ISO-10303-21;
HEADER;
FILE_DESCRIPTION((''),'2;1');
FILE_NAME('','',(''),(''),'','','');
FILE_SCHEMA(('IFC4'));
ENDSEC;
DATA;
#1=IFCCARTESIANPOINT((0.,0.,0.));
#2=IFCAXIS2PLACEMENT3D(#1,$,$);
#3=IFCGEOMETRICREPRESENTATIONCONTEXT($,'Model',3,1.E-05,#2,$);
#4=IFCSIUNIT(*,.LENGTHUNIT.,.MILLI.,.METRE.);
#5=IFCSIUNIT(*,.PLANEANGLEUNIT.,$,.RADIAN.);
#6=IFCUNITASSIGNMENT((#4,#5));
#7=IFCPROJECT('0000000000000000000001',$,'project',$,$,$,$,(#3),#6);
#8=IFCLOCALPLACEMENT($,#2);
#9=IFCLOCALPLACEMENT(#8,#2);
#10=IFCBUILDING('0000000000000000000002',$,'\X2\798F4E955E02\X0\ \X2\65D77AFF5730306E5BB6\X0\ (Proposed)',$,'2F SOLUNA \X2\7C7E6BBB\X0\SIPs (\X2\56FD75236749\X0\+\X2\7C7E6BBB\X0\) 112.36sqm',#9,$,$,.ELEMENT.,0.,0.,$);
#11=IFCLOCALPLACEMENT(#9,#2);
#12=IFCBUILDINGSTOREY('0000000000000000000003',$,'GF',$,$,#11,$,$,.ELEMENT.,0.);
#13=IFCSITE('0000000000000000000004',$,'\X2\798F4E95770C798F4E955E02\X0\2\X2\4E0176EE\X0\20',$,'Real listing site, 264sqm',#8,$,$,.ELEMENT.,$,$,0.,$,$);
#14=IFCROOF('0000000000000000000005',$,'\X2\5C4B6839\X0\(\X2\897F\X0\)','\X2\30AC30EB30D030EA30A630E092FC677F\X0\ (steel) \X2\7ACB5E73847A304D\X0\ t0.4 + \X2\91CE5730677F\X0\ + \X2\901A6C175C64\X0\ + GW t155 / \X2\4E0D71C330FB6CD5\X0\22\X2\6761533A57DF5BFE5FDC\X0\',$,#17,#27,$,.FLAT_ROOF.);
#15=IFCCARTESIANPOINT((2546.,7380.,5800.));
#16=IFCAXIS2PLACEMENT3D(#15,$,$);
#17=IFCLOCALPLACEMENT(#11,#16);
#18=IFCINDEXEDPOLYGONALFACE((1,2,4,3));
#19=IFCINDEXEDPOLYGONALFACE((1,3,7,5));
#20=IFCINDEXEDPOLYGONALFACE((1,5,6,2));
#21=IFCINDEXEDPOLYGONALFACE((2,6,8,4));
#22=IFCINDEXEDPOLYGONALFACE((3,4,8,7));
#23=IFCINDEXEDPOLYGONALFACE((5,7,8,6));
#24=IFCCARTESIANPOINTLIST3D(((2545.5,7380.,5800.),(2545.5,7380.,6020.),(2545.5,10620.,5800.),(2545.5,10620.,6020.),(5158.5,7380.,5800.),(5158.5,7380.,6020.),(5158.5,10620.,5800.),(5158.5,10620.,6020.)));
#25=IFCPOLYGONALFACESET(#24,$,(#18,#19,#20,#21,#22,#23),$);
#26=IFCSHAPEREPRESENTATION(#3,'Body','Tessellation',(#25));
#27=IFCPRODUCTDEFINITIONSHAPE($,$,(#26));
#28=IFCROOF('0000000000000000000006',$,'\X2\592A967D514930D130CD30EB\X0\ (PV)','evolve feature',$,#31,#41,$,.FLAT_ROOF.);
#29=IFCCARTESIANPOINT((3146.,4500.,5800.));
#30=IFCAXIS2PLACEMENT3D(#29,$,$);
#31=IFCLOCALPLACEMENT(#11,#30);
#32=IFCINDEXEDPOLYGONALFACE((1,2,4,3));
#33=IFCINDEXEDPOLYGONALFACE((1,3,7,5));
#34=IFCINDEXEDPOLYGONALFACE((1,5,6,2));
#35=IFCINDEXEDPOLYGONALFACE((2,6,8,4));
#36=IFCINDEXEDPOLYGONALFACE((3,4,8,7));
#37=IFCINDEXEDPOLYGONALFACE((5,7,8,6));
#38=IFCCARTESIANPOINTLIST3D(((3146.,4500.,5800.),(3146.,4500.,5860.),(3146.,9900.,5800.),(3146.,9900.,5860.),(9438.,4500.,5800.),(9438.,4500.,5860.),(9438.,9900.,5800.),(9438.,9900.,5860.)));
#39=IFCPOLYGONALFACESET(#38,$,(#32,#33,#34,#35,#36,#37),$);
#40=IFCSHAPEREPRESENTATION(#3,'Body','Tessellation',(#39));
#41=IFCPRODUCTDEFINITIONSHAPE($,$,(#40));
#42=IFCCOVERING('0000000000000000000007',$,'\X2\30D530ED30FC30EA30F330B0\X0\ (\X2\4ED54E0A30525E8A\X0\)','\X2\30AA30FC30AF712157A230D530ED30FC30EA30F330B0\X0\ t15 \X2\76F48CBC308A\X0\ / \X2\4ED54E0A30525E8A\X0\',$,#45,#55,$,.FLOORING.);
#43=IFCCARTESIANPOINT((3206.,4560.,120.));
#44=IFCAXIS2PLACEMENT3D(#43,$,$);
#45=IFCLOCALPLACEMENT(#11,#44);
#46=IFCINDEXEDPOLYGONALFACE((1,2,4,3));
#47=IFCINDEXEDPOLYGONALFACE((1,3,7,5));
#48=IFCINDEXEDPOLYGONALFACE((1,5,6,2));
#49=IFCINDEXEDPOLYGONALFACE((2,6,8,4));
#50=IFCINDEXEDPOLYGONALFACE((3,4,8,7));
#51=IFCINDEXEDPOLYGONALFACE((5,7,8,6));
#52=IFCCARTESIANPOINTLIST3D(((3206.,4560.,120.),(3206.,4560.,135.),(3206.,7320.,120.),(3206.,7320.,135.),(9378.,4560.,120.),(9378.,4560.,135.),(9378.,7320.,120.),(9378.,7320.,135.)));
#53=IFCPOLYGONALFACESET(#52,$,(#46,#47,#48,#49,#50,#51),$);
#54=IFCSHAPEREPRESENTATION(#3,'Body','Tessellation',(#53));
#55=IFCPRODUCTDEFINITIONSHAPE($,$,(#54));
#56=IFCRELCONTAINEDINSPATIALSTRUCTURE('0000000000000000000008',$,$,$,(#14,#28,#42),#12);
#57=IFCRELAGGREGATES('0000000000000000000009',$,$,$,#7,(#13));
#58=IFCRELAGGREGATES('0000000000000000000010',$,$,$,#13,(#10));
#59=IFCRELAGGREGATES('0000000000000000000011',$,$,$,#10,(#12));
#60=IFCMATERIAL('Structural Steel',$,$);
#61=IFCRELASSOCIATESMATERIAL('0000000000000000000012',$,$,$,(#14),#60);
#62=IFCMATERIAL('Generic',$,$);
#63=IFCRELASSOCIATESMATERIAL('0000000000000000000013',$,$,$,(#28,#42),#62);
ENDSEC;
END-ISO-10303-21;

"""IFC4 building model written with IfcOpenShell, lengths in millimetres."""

from ifc_helpers import new_model, si_unit, frame, frame_2d, origin, place, context, project, spatial, rectangle, extrude, material, element, save


model = new_model("IFC4")

# Units and contexts
model_context = context("Model", 3, precision=1e-05, world=origin())
ifc_project = project(units=[si_unit("LENGTHUNIT", "METRE", prefix="MILLI"), si_unit("PLANEANGLEUNIT", "RADIAN")], contexts=[model_context])

# Site, building, storey
site_placement = place(None, origin())
site = spatial("IfcSite", under=ifc_project, at=site_placement, Name="福井県福井市2丁目20", ObjectType="Real listing site, 264sqm", CompositionType="ELEMENT", RefElevation=0.0)
building_placement = place(site_placement, origin())
building = spatial("IfcBuilding", under=site, at=building_placement, Name="福井市 旗竿地の家 (Proposed)", ObjectType="2F SOLUNA 籾殻SIPs (国産杉+籾殻) 112.36sqm", CompositionType="ELEMENT", ElevationOfRefHeight=0.0, ElevationOfTerrain=0.0)
storey_placement = place(building_placement, origin())
storey = spatial("IfcBuildingStorey", under=building, at=storey_placement, Name="GF", CompositionType="ELEMENT", Elevation=0.0)

# Shared definitions
ifc_material_1 = material(Name="Generic")

# Roofs
ifc_material_2 = material(Name="Structural Steel")
roof_1_placement = place(storey_placement, frame((2546.0, 7380.0, 5800.0)))
element("IfcRoof", 1, at=roof_1_placement, inside=storey, material=ifc_material_2, Name="屋根(西)", Description="ガルバリウム鋼板 (steel) 立平葺き t0.4 + 野地板 + 通気層 + GW t155 / 不燃・法22条区域対応", PredefinedType="FLAT_ROOF", context=model_context, shape_type="SweptSolid", body=[
    extrude(rectangle(XDim=2613.0, YDim=3240.0, at=frame_2d((1306.0, 1620.0))), frame((2546.0, 7380.0, 5800.0)), (0.0, 0.0, 1.0), 220.0),
])
roof_2_placement = place(storey_placement, frame((3146.0, 4500.0, 5800.0)))
element("IfcRoof", 2, at=roof_2_placement, inside=storey, material=ifc_material_1, Name="太陽光パネル (PV)", Description="evolve feature", PredefinedType="FLAT_ROOF", context=model_context, shape_type="SweptSolid", body=[
    extrude(rectangle(XDim=6292.0, YDim=5400.0, at=frame_2d((3146.0, 2700.0))), frame((3146.0, 4500.0, 5800.0)), (0.0, 0.0, 1.0), 60.0),
])

# Covering
covering_placement = place(storey_placement, frame((3206.0, 4560.0, 120.0)))
element("IfcCovering", 3, at=covering_placement, inside=storey, material=ifc_material_1, Name="フローリング (仕上げ床)", Description="オーク無垢フローリング t15 直貼り / 仕上げ床", PredefinedType="FLOORING", context=model_context, shape_type="SweptSolid", body=[
    extrude(rectangle(XDim=6172.0, YDim=2760.0, at=frame_2d((3086.0, 1380.0))), frame((3206.0, 4560.0, 120.0)), (0.0, 0.0, 1.0), 15.0),
])

save(model, "model.ifc")
